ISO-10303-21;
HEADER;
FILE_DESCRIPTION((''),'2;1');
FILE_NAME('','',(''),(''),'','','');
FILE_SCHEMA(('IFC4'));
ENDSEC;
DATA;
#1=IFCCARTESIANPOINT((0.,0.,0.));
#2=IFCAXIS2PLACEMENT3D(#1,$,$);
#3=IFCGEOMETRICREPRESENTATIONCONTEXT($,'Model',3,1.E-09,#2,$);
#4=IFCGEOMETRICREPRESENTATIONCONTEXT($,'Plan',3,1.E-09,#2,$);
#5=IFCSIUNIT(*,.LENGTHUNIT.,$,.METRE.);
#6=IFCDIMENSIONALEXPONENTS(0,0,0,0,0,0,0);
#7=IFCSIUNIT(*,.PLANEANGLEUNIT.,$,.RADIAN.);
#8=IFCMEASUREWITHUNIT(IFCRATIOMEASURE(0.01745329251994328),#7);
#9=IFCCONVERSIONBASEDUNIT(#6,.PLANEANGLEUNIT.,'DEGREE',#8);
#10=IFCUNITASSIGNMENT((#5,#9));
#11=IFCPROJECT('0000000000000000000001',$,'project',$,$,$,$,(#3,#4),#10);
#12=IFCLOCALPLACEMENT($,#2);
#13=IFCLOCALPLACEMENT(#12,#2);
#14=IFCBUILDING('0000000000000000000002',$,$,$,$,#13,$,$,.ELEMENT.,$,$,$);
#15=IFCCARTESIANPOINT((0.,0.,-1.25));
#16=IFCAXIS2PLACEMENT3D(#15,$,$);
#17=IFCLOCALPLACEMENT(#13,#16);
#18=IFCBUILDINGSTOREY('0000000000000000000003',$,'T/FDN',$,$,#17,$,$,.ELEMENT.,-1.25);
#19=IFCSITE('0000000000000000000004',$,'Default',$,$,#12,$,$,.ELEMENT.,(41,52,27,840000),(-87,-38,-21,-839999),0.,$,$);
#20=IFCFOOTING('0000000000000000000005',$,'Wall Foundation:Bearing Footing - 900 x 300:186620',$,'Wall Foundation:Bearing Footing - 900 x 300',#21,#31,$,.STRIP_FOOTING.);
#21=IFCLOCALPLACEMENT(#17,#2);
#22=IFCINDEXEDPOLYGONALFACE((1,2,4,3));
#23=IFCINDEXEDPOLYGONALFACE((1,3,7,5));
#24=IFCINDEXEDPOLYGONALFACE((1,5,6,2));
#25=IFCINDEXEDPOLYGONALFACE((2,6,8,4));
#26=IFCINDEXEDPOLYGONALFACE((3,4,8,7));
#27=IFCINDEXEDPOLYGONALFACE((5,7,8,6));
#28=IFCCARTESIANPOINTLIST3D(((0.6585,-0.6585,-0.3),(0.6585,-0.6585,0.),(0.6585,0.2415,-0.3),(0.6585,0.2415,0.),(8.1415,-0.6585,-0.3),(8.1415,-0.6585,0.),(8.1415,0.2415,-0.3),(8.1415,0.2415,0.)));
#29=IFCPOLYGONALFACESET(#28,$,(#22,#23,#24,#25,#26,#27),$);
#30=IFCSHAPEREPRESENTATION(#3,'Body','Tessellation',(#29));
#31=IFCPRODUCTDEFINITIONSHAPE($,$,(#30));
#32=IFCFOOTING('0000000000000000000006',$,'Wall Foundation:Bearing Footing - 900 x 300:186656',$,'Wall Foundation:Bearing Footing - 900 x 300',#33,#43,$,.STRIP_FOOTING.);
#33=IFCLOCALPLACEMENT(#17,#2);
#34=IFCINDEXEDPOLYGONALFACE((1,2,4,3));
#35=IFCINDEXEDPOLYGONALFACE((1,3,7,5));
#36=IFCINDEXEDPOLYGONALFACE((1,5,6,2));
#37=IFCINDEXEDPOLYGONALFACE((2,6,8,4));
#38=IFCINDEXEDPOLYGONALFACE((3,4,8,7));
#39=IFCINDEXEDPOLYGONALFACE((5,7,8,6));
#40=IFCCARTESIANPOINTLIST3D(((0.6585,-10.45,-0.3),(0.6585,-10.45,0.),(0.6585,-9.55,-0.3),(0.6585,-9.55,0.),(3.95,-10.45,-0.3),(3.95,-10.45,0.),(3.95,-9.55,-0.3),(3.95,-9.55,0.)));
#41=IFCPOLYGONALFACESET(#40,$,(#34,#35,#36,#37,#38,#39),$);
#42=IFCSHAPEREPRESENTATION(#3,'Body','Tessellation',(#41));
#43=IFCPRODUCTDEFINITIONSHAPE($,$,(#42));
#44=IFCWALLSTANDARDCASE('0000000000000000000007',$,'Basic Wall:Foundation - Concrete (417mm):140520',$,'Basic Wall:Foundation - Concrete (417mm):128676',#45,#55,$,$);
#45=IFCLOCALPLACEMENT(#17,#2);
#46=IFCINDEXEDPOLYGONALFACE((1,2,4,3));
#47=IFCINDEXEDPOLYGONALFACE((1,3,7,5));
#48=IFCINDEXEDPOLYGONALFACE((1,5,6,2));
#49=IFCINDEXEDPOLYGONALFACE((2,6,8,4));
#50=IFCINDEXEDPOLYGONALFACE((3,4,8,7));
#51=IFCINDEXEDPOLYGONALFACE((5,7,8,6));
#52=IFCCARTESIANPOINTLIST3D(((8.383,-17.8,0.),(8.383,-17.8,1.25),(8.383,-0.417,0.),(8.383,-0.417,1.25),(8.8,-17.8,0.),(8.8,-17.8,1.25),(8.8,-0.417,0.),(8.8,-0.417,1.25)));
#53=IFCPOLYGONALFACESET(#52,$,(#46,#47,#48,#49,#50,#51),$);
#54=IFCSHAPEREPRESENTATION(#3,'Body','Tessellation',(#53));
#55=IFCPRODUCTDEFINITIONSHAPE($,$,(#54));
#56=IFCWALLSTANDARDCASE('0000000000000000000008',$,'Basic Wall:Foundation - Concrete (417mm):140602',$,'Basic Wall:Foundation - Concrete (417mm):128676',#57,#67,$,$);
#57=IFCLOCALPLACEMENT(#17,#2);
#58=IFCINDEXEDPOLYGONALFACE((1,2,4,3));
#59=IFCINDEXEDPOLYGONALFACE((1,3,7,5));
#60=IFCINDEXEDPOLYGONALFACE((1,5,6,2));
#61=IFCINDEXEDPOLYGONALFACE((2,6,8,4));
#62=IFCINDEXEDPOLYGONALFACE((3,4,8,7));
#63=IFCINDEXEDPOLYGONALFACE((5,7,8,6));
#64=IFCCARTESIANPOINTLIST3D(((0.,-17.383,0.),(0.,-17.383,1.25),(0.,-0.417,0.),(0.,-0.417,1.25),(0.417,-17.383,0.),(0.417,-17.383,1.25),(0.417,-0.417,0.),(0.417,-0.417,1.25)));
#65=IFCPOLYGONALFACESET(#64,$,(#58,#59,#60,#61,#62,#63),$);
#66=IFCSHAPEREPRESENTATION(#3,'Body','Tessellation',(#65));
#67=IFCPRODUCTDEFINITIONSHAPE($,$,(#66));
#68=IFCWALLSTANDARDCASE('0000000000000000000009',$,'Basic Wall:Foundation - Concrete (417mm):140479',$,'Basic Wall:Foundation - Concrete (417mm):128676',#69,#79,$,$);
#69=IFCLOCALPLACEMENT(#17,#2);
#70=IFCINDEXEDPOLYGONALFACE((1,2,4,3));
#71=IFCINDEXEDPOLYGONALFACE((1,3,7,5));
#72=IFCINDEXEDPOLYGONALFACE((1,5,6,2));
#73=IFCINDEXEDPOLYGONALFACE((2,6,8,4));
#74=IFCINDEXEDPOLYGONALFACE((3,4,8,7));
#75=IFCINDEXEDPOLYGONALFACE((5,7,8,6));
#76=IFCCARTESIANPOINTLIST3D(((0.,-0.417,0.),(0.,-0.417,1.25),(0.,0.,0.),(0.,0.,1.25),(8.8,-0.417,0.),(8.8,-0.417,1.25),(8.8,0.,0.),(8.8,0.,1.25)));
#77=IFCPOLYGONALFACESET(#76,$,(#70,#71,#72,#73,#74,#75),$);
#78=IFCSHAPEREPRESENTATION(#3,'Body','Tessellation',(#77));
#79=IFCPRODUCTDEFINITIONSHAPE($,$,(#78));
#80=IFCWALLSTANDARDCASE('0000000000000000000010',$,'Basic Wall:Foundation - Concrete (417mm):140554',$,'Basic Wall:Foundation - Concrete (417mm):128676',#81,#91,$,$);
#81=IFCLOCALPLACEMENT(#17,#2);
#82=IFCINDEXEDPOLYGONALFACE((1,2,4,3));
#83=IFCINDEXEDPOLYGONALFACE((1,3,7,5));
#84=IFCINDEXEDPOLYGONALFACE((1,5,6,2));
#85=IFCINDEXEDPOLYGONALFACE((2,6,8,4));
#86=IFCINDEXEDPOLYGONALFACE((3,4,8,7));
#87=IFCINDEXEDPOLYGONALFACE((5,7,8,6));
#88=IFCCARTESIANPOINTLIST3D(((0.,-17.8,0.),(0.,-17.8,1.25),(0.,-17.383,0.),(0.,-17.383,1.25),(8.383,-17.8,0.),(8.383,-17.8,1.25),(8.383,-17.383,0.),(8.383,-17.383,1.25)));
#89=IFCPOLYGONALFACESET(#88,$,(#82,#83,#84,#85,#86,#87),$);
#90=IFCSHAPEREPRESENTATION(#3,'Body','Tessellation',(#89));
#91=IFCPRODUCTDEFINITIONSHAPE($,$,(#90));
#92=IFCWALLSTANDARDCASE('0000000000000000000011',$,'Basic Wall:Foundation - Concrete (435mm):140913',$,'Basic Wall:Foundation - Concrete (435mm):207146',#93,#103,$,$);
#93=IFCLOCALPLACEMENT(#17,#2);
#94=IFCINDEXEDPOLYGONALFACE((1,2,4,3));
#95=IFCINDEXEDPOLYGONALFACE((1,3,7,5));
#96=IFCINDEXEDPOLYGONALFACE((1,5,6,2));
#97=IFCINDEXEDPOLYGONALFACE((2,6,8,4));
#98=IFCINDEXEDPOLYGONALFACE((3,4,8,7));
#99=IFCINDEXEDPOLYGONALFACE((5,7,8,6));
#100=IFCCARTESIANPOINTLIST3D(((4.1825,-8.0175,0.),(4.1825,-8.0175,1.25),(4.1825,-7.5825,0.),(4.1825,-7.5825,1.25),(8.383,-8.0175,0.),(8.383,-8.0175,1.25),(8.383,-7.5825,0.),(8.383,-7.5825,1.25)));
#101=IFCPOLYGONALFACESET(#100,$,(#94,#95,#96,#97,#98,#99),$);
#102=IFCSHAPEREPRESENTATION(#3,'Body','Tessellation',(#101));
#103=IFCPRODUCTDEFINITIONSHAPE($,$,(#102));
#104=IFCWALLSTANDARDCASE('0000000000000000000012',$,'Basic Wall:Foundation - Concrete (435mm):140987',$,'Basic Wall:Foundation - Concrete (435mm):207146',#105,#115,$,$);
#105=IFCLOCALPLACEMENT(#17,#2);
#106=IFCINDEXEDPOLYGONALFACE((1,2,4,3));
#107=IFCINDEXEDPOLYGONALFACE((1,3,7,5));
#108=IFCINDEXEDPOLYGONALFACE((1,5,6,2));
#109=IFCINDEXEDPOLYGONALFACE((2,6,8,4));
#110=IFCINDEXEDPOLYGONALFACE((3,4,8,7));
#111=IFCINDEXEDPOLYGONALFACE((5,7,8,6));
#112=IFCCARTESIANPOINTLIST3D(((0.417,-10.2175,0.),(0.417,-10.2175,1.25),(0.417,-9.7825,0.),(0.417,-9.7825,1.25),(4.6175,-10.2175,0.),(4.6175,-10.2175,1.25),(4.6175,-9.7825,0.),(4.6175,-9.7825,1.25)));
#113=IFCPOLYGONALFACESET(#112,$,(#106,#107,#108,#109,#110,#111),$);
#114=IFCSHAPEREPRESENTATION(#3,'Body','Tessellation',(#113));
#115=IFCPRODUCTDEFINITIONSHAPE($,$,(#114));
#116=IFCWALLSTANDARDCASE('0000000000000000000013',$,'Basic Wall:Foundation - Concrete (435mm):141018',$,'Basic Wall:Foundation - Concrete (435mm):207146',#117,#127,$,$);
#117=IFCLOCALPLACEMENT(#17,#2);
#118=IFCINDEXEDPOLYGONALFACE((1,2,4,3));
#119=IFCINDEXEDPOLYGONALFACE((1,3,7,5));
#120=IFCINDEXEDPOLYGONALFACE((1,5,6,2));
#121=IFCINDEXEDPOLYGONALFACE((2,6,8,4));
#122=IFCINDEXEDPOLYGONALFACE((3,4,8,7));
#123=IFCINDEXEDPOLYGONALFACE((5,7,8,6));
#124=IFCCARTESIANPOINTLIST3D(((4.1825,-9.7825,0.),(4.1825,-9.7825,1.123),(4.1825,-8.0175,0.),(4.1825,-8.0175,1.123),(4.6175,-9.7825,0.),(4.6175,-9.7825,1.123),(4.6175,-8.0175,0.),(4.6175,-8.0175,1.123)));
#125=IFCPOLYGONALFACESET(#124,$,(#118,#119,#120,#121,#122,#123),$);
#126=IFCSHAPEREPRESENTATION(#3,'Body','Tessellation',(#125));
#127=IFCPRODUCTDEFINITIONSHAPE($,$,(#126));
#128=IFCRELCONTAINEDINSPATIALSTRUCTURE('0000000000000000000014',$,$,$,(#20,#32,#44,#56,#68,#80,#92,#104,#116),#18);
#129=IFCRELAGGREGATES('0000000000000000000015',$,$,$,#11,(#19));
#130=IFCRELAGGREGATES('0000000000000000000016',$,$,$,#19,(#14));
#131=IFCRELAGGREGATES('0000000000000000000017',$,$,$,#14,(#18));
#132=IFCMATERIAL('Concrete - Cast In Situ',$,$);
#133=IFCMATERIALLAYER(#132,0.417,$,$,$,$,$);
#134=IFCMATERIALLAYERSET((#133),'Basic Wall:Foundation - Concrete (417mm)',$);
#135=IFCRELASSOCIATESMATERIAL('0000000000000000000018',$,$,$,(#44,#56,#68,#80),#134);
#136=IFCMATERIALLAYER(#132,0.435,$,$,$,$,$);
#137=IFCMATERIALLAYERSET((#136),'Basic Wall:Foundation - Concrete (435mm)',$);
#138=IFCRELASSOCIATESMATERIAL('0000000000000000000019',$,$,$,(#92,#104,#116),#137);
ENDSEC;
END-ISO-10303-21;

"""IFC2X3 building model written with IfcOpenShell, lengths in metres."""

from ifc_helpers import new_model, entity, si_unit, converted_unit, frame, frame_2d, origin, origin_2d_with_axis, place, context, project, spatial, rectangle, extrude, material, layer, layer_set, layer_usage, element, save


model = new_model("IFC2X3")

# Units and contexts
model_context = context("Model", 3, precision=1e-09, world=origin())
plan_context = context("Plan", 3, precision=1e-09, world=origin())
ifc_project = project(units=[si_unit("LENGTHUNIT", "METRE"), converted_unit("PLANEANGLEUNIT", "DEGREE", entity("IfcRatioMeasure", 0.01745329251994328), si_unit("PLANEANGLEUNIT", "RADIAN"), dimensions=[0, 0, 0, 0, 0, 0, 0])], contexts=[model_context, plan_context])

# Site, building, storey
site_placement = place(None, origin())
site = spatial("IfcSite", under=ifc_project, at=site_placement, Name="Default", CompositionType="ELEMENT", RefLatitude=(41, 52, 27, 840000), RefLongitude=(-87, -38, -21, -839999), RefElevation=0.0)
building_placement = place(site_placement, origin())
building = spatial("IfcBuilding", under=site, at=building_placement, CompositionType="ELEMENT")
storey_placement = place(building_placement, frame((0.0, 0.0, -1.25)))
storey = spatial("IfcBuildingStorey", under=building, at=storey_placement, Name="T/FDN", CompositionType="ELEMENT", Elevation=-1.25)

# Footings
footing_1_placement = place(storey_placement, origin())
element("IfcFooting", 1, at=footing_1_placement, inside=storey, Name="Wall Foundation:Bearing Footing - 900 x 300:186620", ObjectType="Wall Foundation:Bearing Footing - 900 x 300", PredefinedType="STRIP_FOOTING", context=model_context, shape_type="SweptSolid", body=[
    extrude(rectangle(XDim=7.483, YDim=0.9, at=origin_2d_with_axis()), frame((4.4, -0.2085, -0.3), z_axis=(0.0, 0.0, 1.0), x_axis=(-1.0, 0.0, 0.0)), (0.0, 0.0, 1.0), 0.3),
])
footing_2_placement = place(storey_placement, origin())
element("IfcFooting", 2, at=footing_2_placement, inside=storey, Name="Wall Foundation:Bearing Footing - 900 x 300:186656", ObjectType="Wall Foundation:Bearing Footing - 900 x 300", PredefinedType="STRIP_FOOTING", context=model_context, shape_type="SweptSolid", body=[
    extrude(rectangle(XDim=3.2915, YDim=0.9, at=origin_2d_with_axis()), frame((2.3042, -10.0, -0.3)), (0.0, 0.0, 1.0), 0.3),
])

# Walls
ifc_material = material(Name="Concrete - Cast In Situ")
ifc_layer_1 = layer(ifc_material, 0.417)
ifc_layer_set_1 = layer_set([ifc_layer_1], Name="Basic Wall:Foundation - Concrete (417mm)")
ifc_layer_usage_1 = layer_usage(ifc_layer_set_1, "AXIS2", "NEGATIVE", 0.2085)
wall_1_placement = place(storey_placement, frame((8.5915, -0.417, 0.0), z_axis=(0.0, 0.0, 1.0), x_axis=(0.0, -1.0, 0.0)))
element("IfcWallStandardCase", 3, at=wall_1_placement, inside=storey, material=ifc_layer_usage_1, Name="Basic Wall:Foundation - Concrete (417mm):140520", ObjectType="Basic Wall:Foundation - Concrete (417mm):128676", context=model_context, shape_type="SweptSolid", body=[
    extrude(rectangle(XDim=17.383, YDim=0.417, at=frame_2d((8.6915, 0.0), x_axis=(-1.0, 0.0))), origin(), (0.0, 0.0, 1.0), 1.25),
])
wall_2_placement = place(storey_placement, frame((0.2085, -17.383, 0.0), z_axis=(0.0, 0.0, 1.0), x_axis=(0.0, 1.0, 0.0)))
element("IfcWallStandardCase", 4, at=wall_2_placement, inside=storey, material=ifc_layer_usage_1, Name="Basic Wall:Foundation - Concrete (417mm):140602", ObjectType="Basic Wall:Foundation - Concrete (417mm):128676", context=model_context, shape_type="SweptSolid", body=[
    extrude(rectangle(XDim=16.966, YDim=0.417, at=frame_2d((8.483, 0.0), x_axis=(-1.0, 0.0))), origin(), (0.0, 0.0, 1.0), 1.25),
])
wall_3_placement = place(storey_placement, frame((0.0, -0.2085, 0.0)))
element("IfcWallStandardCase", 5, at=wall_3_placement, inside=storey, material=ifc_layer_usage_1, Name="Basic Wall:Foundation - Concrete (417mm):140479", ObjectType="Basic Wall:Foundation - Concrete (417mm):128676", context=model_context, shape_type="SweptSolid", body=[
    extrude(rectangle(XDim=8.8, YDim=0.417, at=frame_2d((4.4, 0.0), x_axis=(-1.0, 0.0))), origin(), (0.0, 0.0, 1.0), 1.25),
])
wall_4_placement = place(storey_placement, frame((8.383, -17.5915, 0.0), z_axis=(0.0, 0.0, 1.0), x_axis=(-1.0, 0.0, 0.0)))
element("IfcWallStandardCase", 6, at=wall_4_placement, inside=storey, material=ifc_layer_usage_1, Name="Basic Wall:Foundation - Concrete (417mm):140554", ObjectType="Basic Wall:Foundation - Concrete (417mm):128676", context=model_context, shape_type="SweptSolid", body=[
    extrude(rectangle(XDim=8.383, YDim=0.417, at=frame_2d((4.1915, 0.0), x_axis=(-1.0, 0.0))), origin(), (0.0, 0.0, 1.0), 1.25),
])
ifc_layer_2 = layer(ifc_material, 0.435)
ifc_layer_set_2 = layer_set([ifc_layer_2], Name="Basic Wall:Foundation - Concrete (435mm)")
ifc_layer_usage_2 = layer_usage(ifc_layer_set_2, "AXIS2", "NEGATIVE", 0.2175)
wall_5_placement = place(storey_placement, frame((8.383, -7.8, 0.0), z_axis=(0.0, 0.0, 1.0), x_axis=(-1.0, 0.0, 0.0)))
element("IfcWallStandardCase", 7, at=wall_5_placement, inside=storey, material=ifc_layer_usage_2, Name="Basic Wall:Foundation - Concrete (435mm):140913", ObjectType="Basic Wall:Foundation - Concrete (435mm):207146", context=model_context, shape_type="SweptSolid", body=[
    extrude(rectangle(XDim=4.2005, YDim=0.435, at=frame_2d((2.1002, 0.0), x_axis=(-1.0, 0.0))), origin(), (0.0, 0.0, 1.0), 1.25),
])
wall_6_placement = place(storey_placement, frame((0.417, -10.0, 0.0)))
element("IfcWallStandardCase", 8, at=wall_6_placement, inside=storey, material=ifc_layer_usage_2, Name="Basic Wall:Foundation - Concrete (435mm):140987", ObjectType="Basic Wall:Foundation - Concrete (435mm):207146", context=model_context, shape_type="SweptSolid", body=[
    extrude(rectangle(XDim=4.2005, YDim=0.435, at=frame_2d((2.1002, 0.0), x_axis=(-1.0, 0.0))), origin(), (0.0, 0.0, 1.0), 1.25),
])
wall_7_placement = place(storey_placement, frame((4.4, -9.7825, 0.0), z_axis=(0.0, 0.0, 1.0), x_axis=(0.0, 1.0, 0.0)))
element("IfcWallStandardCase", 9, at=wall_7_placement, inside=storey, material=ifc_layer_usage_2, Name="Basic Wall:Foundation - Concrete (435mm):141018", ObjectType="Basic Wall:Foundation - Concrete (435mm):207146", context=model_context, shape_type="SweptSolid", body=[
    extrude(rectangle(XDim=1.765, YDim=0.435, at=frame_2d((0.8825, 0.0), x_axis=(-1.0, 0.0))), origin(), (0.0, 0.0, 1.0), 1.123),
])

save(model, "model.ifc")
